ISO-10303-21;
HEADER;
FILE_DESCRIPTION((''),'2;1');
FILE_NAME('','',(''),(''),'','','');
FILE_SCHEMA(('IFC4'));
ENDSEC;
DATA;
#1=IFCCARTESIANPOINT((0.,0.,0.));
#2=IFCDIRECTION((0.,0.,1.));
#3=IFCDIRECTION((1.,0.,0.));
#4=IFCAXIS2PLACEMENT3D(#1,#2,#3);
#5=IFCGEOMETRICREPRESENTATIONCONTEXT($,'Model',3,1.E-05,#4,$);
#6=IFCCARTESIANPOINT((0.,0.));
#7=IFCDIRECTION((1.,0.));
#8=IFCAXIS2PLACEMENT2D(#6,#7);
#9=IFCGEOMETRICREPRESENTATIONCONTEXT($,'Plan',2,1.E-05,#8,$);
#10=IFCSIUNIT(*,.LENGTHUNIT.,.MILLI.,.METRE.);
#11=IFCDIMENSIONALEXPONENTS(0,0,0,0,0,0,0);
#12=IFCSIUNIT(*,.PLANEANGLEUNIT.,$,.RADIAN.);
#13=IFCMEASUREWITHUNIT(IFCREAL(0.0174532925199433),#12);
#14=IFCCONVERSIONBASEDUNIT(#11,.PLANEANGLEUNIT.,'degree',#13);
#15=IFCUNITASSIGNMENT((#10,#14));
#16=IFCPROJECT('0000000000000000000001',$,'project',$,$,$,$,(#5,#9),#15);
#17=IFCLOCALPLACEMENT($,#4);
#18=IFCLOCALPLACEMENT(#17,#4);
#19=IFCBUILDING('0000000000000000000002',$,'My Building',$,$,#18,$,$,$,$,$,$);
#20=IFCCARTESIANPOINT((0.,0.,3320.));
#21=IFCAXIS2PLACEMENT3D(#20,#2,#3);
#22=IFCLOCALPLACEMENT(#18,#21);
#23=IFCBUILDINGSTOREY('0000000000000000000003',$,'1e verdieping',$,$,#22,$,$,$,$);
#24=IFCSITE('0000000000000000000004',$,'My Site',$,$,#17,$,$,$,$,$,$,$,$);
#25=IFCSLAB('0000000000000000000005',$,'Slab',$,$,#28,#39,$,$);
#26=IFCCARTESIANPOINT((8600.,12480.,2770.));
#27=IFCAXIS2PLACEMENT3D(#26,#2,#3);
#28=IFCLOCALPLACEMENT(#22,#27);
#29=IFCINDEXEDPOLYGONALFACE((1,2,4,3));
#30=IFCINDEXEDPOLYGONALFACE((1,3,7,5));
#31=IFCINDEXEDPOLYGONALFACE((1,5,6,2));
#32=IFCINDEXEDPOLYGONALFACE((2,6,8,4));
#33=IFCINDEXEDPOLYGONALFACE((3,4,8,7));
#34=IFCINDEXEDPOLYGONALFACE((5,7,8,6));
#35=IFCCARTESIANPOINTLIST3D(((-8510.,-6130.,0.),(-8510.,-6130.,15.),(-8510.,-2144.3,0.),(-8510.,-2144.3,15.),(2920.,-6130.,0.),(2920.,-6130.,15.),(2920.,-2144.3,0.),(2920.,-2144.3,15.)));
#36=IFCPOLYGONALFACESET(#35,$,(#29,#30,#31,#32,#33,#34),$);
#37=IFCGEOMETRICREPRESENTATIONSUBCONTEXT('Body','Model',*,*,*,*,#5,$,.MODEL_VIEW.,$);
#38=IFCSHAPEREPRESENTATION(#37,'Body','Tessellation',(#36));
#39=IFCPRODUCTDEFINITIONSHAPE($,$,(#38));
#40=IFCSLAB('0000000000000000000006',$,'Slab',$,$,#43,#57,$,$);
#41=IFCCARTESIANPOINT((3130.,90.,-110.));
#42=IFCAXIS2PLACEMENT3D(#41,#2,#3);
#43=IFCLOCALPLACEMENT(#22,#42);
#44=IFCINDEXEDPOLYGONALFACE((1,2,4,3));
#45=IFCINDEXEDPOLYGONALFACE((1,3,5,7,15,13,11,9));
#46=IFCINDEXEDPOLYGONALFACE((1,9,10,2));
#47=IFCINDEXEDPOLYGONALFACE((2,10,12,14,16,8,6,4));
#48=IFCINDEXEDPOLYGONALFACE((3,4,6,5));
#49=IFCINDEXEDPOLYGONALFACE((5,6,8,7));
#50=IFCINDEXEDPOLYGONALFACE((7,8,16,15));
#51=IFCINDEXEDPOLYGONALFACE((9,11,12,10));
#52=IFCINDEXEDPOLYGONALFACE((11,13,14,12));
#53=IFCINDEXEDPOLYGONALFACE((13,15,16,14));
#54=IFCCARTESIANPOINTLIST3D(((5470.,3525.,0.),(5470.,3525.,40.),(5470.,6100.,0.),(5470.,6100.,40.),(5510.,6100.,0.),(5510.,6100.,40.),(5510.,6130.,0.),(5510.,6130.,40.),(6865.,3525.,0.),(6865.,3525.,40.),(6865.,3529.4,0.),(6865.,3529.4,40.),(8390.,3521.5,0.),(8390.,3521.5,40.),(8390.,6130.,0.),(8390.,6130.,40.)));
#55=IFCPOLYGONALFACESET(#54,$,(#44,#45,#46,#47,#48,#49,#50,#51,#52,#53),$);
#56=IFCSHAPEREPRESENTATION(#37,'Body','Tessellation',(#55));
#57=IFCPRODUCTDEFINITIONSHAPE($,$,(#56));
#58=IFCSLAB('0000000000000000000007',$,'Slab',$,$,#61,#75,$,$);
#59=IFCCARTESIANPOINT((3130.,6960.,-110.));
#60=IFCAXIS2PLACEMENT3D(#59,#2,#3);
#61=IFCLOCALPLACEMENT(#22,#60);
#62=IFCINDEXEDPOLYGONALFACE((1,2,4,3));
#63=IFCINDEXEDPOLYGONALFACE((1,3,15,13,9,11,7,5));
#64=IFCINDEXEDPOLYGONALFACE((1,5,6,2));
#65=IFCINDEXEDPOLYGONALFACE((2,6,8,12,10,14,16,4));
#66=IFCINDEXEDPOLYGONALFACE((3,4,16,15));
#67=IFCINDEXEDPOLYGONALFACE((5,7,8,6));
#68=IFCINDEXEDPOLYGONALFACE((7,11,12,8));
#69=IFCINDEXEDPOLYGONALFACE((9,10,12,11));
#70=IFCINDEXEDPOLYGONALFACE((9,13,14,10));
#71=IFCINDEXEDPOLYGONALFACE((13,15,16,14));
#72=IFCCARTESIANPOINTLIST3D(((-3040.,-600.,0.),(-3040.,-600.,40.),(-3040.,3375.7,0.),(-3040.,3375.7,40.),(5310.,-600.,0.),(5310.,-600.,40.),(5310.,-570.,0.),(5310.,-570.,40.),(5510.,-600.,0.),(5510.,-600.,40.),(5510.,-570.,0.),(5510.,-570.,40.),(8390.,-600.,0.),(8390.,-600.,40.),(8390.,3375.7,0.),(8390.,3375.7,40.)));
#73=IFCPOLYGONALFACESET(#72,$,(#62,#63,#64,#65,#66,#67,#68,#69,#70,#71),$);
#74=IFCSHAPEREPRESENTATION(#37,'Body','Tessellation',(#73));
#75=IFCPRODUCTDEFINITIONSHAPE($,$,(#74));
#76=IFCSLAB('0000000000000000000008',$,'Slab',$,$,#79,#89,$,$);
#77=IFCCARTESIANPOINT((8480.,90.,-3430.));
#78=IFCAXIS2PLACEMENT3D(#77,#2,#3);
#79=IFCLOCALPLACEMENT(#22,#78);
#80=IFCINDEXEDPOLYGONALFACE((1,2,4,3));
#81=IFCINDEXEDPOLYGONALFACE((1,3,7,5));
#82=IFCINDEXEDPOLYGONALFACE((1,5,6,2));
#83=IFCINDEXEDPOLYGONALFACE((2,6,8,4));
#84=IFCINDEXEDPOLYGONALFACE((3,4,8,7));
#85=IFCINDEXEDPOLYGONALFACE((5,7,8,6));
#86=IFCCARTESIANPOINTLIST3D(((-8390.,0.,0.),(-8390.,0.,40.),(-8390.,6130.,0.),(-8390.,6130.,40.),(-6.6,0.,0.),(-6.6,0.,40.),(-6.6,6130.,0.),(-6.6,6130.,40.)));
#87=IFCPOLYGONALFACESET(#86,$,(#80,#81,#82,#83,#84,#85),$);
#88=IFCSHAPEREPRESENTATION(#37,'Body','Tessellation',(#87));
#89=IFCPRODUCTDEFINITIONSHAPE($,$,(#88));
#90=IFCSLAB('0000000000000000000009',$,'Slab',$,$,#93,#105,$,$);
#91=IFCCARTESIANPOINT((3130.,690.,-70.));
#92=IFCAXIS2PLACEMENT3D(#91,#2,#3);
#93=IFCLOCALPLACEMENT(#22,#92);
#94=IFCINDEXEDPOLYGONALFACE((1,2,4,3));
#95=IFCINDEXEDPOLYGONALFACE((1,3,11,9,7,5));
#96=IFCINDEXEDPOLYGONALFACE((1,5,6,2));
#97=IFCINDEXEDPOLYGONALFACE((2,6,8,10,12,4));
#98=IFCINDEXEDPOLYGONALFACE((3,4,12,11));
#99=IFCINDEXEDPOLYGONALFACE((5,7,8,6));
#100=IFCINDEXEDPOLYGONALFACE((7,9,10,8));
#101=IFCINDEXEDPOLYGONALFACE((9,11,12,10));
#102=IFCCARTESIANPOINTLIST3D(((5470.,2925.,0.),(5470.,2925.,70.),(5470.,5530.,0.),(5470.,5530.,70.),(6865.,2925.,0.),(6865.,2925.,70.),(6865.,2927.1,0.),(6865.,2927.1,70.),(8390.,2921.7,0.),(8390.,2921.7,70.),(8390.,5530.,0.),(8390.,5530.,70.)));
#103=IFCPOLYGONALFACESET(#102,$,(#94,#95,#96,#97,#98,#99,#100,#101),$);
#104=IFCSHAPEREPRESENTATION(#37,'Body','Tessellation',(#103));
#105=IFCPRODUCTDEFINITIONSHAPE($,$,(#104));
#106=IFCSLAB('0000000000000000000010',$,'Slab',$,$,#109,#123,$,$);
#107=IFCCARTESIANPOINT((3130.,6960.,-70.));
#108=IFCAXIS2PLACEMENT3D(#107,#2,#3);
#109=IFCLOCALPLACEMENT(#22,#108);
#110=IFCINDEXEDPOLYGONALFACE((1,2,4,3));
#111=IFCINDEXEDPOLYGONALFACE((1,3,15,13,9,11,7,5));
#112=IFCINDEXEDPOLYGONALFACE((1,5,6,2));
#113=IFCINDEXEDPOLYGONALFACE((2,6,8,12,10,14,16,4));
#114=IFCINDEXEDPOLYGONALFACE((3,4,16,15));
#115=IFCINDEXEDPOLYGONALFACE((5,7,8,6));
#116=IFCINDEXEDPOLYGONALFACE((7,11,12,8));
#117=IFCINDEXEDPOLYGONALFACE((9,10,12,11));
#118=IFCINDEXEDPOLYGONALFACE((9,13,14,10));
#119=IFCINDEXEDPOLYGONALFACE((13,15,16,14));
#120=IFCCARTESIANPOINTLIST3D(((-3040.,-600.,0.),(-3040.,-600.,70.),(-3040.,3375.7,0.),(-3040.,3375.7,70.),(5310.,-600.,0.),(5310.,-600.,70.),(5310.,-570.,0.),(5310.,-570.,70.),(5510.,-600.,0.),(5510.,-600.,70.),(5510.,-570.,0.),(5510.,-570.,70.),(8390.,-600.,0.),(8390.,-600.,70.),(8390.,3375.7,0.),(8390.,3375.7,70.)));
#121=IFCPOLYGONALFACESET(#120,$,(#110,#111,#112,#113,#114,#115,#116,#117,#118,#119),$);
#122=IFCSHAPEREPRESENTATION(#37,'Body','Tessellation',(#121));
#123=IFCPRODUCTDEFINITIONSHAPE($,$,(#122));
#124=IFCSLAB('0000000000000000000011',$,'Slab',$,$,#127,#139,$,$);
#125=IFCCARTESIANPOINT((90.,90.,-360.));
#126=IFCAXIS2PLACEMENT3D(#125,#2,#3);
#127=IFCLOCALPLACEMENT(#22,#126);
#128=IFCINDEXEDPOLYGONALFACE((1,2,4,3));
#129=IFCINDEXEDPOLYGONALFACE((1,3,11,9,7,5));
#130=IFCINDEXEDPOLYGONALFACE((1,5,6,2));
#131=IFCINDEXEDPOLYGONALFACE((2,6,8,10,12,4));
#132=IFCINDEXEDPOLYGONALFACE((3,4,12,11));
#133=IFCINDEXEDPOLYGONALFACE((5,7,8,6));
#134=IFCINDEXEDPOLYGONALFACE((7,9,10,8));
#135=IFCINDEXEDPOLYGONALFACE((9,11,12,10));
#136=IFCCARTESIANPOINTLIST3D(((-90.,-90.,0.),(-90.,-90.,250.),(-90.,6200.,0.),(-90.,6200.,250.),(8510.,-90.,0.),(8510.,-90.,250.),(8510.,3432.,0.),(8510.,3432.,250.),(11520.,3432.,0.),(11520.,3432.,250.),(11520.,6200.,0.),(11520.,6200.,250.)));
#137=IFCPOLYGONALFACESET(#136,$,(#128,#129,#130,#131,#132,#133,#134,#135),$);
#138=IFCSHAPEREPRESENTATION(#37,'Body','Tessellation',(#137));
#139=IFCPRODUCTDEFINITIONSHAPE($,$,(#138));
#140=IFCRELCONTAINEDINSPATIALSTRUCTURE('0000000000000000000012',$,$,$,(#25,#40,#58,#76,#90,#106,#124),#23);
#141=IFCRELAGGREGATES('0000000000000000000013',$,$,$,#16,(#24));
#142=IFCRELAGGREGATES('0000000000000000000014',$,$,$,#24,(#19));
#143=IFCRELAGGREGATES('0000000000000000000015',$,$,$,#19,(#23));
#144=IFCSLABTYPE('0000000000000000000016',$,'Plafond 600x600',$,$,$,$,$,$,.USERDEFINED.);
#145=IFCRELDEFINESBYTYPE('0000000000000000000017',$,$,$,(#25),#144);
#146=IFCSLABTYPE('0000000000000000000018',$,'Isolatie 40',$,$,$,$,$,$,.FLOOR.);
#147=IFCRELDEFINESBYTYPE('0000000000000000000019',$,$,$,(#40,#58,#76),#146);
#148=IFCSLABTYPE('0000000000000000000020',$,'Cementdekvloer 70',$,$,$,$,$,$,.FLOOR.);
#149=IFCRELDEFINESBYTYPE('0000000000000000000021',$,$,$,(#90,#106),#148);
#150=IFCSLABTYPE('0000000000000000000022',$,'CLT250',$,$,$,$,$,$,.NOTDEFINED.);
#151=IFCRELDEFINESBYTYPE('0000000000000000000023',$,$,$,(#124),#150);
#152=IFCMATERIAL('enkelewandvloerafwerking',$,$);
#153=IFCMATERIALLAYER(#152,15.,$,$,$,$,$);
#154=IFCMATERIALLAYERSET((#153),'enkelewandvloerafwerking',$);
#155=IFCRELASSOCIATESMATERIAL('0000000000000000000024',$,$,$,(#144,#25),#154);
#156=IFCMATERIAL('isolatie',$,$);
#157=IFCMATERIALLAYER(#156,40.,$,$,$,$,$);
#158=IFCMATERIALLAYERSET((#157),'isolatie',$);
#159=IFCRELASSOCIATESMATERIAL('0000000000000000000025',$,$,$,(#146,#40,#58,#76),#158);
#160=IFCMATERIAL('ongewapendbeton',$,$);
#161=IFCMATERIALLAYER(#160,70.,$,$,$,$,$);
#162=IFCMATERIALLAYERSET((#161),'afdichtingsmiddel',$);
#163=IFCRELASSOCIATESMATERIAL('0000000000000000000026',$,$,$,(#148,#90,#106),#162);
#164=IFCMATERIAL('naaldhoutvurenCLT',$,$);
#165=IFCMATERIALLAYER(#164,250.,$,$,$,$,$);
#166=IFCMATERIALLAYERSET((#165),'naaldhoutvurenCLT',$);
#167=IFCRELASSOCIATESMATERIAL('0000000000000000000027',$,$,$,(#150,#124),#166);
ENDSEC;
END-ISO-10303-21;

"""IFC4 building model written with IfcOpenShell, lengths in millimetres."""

from ifc_helpers import new_model, entity, si_unit, converted_unit, frame, origin_with_axes, origin_2d_with_axis, place, context, subcontext, project, spatial, line, indexed_curve, outline, extrude, material, layer, layer_set, layer_usage, type_object, element, save


model = new_model("IFC4")

# Units and contexts
model_context = context("Model", 3, precision=1e-05, world=origin_with_axes())
plan_context = context("Plan", 2, precision=1e-05, world=origin_2d_with_axis())
body_context = subcontext(model_context, "Body", "Model", "MODEL_VIEW")
ifc_project = project(units=[si_unit("LENGTHUNIT", "METRE", prefix="MILLI"), converted_unit("PLANEANGLEUNIT", "degree", entity("IfcReal", 0.0174532925199433), si_unit("PLANEANGLEUNIT", "RADIAN"), dimensions=[0, 0, 0, 0, 0, 0, 0])], contexts=[model_context, plan_context])

# Site, building, storey
site_placement = place(None, origin_with_axes())
site = spatial("IfcSite", under=ifc_project, at=site_placement, Name="My Site")
building_placement = place(site_placement, origin_with_axes())
building = spatial("IfcBuilding", under=site, at=building_placement, Name="My Building")
storey_placement = place(building_placement, frame((0.0, 0.0, 3320.0), z_axis=(0.0, 0.0, 1.0), x_axis=(1.0, 0.0, 0.0)))
storey = spatial("IfcBuildingStorey", under=building, at=storey_placement, Name="1e verdieping")

# Shared definitions
ifc_material_1 = material(Name="naaldhoutvurenCLT")

# Slabs
ifc_material_2 = material(Name="enkelewandvloerafwerking")
ifc_layer_1 = layer(ifc_material_2, 15.0)
ifc_layer_set_1 = layer_set([ifc_layer_1], Name="enkelewandvloerafwerking")
slab_type_1 = type_object("IfcSlabType", Name="Plafond 600x600", PredefinedType="USERDEFINED", material=ifc_layer_set_1)
ifc_layer_usage_1 = layer_usage(ifc_layer_set_1, "AXIS3", "POSITIVE", 0.0)
slab_1_placement = place(storey_placement, frame((8600.0, 12480.0, 2770.0), z_axis=(0.0, 0.0, 1.0), x_axis=(1.0, 0.0, 0.0)))
element("IfcSlab", 1, at=slab_1_placement, inside=storey, type_object=slab_type_1, material=ifc_layer_usage_1, Name="Slab", context=body_context, shape_type="SweptSolid", body=[
    extrude(outline(indexed_curve([(-8510.0, -2144.3), (-8510.0, -6130.0), (2920.0, -6130.0), (2920.0, -2144.3)], segments=[line(4, 1), line(1, 2), line(2, 3), line(3, 4)], self_intersect=False)), None, (0.0, 0.0, 1.0), 15.0),
])
ifc_material_3 = material(Name="isolatie")
ifc_layer_2 = layer(ifc_material_3, 40.0)
ifc_layer_set_2 = layer_set([ifc_layer_2], Name="isolatie")
ifc_layer_usage_2 = layer_usage(ifc_layer_set_2, "AXIS3", "POSITIVE", 0.0)
slab_type_2 = type_object("IfcSlabType", Name="Isolatie 40", PredefinedType="FLOOR", material=ifc_layer_set_2)
slab_2_placement = place(storey_placement, frame((3130.0, 90.0, -110.0), z_axis=(0.0, 0.0, 1.0), x_axis=(1.0, 0.0, 0.0)))
element("IfcSlab", 2, at=slab_2_placement, inside=storey, type_object=slab_type_2, material=ifc_layer_usage_2, Name="Slab", context=body_context, shape_type="SweptSolid", body=[
    extrude(outline(indexed_curve([(5510.0, 6100.0), (5510.0, 6130.0), (8390.0, 6130.0), (8390.0, 3521.5), (6865.0, 3529.4), (6865.0, 3525.0), (5470.0, 3525.0), (5470.0, 6100.0)], segments=[line(5, 6), line(6, 7), line(7, 8), line(8, 1), line(1, 2), line(2, 3), line(3, 4), line(4, 5)], self_intersect=False)), None, (0.0, 0.0, 1.0), 40.0),
])
ifc_layer_usage_3 = layer_usage(ifc_layer_set_2, "AXIS3", "POSITIVE", 0.0)
slab_3_placement = place(storey_placement, frame((3130.0, 6960.0, -110.0), z_axis=(0.0, 0.0, 1.0), x_axis=(1.0, 0.0, 0.0)))
element("IfcSlab", 3, at=slab_3_placement, inside=storey, type_object=slab_type_2, material=ifc_layer_usage_3, Name="Slab", context=body_context, shape_type="SweptSolid", body=[
    extrude(outline(indexed_curve([(5310.0, -570.0), (5510.0, -570.0), (5510.0, -600.0), (8390.0, -600.0), (8390.0, 3375.7), (-3040.0, 3375.7), (-3040.0, -600.0), (5310.0, -600.0)], segments=[line(5, 4), line(4, 3), line(3, 2), line(2, 1), line(1, 8), line(8, 7), line(7, 6), line(6, 5)], self_intersect=False)), None, (0.0, 0.0, 1.0), 40.0),
])
ifc_layer_usage_4 = layer_usage(ifc_layer_set_2, "AXIS3", "POSITIVE", 0.0)
slab_4_placement = place(storey_placement, frame((8480.0, 90.0, -3430.0), z_axis=(0.0, 0.0, 1.0), x_axis=(1.0, 0.0, 0.0)))
element("IfcSlab", 4, at=slab_4_placement, inside=storey, type_object=slab_type_2, material=ifc_layer_usage_4, Name="Slab", context=body_context, shape_type="SweptSolid", body=[
    extrude(outline(indexed_curve([(-8390.0, 0.0), (-6.6, 0.0), (-6.6, 6130.0), (-8390.0, 6130.0)], segments=[line(4, 1), line(1, 2), line(2, 3), line(3, 4)], self_intersect=False)), None, (0.0, 0.0, 1.0), 40.0),
])
ifc_material_4 = material(Name="ongewapendbeton")
ifc_layer_3 = layer(ifc_material_4, 70.0)
ifc_layer_set_3 = layer_set([ifc_layer_3], Name="afdichtingsmiddel")
ifc_layer_usage_5 = layer_usage(ifc_layer_set_3, "AXIS3", "POSITIVE", 0.0)
slab_type_3 = type_object("IfcSlabType", Name="Cementdekvloer 70", PredefinedType="FLOOR", material=ifc_layer_set_3)
slab_5_placement = place(storey_placement, frame((3130.0, 690.0, -70.0), z_axis=(0.0, 0.0, 1.0), x_axis=(1.0, 0.0, 0.0)))
element("IfcSlab", 5, at=slab_5_placement, inside=storey, type_object=slab_type_3, material=ifc_layer_usage_5, Name="Slab", context=body_context, shape_type="SweptSolid", body=[
    extrude(outline(indexed_curve([(6865.0, 2925.0), (5470.0, 2925.0), (5470.0, 5530.0), (8390.0, 5530.0), (8390.0, 2921.7), (6865.0, 2927.1)], segments=[line(5, 4), line(4, 3), line(3, 2), line(2, 1), line(1, 6), line(6, 5)], self_intersect=False)), None, (0.0, 0.0, 1.0), 70.0),
])
ifc_layer_usage_6 = layer_usage(ifc_layer_set_3, "AXIS3", "POSITIVE", 0.0)
slab_6_placement = place(storey_placement, frame((3130.0, 6960.0, -70.0), z_axis=(0.0, 0.0, 1.0), x_axis=(1.0, 0.0, 0.0)))
element("IfcSlab", 6, at=slab_6_placement, inside=storey, type_object=slab_type_3, material=ifc_layer_usage_6, Name="Slab", context=body_context, shape_type="SweptSolid", body=[
    extrude(outline(indexed_curve([(-3040.0, -600.0), (-3040.0, 3375.7), (8390.0, 3375.7), (8390.0, -600.0), (5510.0, -600.0), (5510.0, -570.0), (5310.0, -570.0), (5310.0, -600.0)], segments=[line(1, 8), line(8, 7), line(7, 6), line(6, 5), line(5, 4), line(4, 3), line(3, 2), line(2, 1)], self_intersect=False)), None, (0.0, 0.0, 1.0), 70.0),
])
ifc_layer_4 = layer(ifc_material_1, 250.0)
ifc_layer_set_4 = layer_set([ifc_layer_4], Name="naaldhoutvurenCLT")
slab_type_4 = type_object("IfcSlabType", Name="CLT250", PredefinedType="NOTDEFINED", material=ifc_layer_set_4)
ifc_layer_usage_7 = layer_usage(ifc_layer_set_4, "AXIS3", "POSITIVE", 0.0)
slab_7_placement = place(storey_placement, frame((90.0, 90.0, -360.0), z_axis=(0.0, 0.0, 1.0), x_axis=(1.0, 0.0, 0.0)))
element("IfcSlab", 7, at=slab_7_placement, inside=storey, type_object=slab_type_4, material=ifc_layer_usage_7, Name="Slab", context=body_context, shape_type="SweptSolid", body=[
    extrude(outline(indexed_curve([(-90.0, -90.0), (-90.0, 6200.0), (11520.0, 6200.0), (11520.0, 3432.0), (8510.0, 3432.0), (8510.0, -90.0)], segments=[line(6, 5), line(5, 4), line(4, 3), line(3, 2), line(2, 1), line(1, 6)], self_intersect=False)), None, (0.0, 0.0, 1.0), 250.0),
])

save(model, "model.ifc")
